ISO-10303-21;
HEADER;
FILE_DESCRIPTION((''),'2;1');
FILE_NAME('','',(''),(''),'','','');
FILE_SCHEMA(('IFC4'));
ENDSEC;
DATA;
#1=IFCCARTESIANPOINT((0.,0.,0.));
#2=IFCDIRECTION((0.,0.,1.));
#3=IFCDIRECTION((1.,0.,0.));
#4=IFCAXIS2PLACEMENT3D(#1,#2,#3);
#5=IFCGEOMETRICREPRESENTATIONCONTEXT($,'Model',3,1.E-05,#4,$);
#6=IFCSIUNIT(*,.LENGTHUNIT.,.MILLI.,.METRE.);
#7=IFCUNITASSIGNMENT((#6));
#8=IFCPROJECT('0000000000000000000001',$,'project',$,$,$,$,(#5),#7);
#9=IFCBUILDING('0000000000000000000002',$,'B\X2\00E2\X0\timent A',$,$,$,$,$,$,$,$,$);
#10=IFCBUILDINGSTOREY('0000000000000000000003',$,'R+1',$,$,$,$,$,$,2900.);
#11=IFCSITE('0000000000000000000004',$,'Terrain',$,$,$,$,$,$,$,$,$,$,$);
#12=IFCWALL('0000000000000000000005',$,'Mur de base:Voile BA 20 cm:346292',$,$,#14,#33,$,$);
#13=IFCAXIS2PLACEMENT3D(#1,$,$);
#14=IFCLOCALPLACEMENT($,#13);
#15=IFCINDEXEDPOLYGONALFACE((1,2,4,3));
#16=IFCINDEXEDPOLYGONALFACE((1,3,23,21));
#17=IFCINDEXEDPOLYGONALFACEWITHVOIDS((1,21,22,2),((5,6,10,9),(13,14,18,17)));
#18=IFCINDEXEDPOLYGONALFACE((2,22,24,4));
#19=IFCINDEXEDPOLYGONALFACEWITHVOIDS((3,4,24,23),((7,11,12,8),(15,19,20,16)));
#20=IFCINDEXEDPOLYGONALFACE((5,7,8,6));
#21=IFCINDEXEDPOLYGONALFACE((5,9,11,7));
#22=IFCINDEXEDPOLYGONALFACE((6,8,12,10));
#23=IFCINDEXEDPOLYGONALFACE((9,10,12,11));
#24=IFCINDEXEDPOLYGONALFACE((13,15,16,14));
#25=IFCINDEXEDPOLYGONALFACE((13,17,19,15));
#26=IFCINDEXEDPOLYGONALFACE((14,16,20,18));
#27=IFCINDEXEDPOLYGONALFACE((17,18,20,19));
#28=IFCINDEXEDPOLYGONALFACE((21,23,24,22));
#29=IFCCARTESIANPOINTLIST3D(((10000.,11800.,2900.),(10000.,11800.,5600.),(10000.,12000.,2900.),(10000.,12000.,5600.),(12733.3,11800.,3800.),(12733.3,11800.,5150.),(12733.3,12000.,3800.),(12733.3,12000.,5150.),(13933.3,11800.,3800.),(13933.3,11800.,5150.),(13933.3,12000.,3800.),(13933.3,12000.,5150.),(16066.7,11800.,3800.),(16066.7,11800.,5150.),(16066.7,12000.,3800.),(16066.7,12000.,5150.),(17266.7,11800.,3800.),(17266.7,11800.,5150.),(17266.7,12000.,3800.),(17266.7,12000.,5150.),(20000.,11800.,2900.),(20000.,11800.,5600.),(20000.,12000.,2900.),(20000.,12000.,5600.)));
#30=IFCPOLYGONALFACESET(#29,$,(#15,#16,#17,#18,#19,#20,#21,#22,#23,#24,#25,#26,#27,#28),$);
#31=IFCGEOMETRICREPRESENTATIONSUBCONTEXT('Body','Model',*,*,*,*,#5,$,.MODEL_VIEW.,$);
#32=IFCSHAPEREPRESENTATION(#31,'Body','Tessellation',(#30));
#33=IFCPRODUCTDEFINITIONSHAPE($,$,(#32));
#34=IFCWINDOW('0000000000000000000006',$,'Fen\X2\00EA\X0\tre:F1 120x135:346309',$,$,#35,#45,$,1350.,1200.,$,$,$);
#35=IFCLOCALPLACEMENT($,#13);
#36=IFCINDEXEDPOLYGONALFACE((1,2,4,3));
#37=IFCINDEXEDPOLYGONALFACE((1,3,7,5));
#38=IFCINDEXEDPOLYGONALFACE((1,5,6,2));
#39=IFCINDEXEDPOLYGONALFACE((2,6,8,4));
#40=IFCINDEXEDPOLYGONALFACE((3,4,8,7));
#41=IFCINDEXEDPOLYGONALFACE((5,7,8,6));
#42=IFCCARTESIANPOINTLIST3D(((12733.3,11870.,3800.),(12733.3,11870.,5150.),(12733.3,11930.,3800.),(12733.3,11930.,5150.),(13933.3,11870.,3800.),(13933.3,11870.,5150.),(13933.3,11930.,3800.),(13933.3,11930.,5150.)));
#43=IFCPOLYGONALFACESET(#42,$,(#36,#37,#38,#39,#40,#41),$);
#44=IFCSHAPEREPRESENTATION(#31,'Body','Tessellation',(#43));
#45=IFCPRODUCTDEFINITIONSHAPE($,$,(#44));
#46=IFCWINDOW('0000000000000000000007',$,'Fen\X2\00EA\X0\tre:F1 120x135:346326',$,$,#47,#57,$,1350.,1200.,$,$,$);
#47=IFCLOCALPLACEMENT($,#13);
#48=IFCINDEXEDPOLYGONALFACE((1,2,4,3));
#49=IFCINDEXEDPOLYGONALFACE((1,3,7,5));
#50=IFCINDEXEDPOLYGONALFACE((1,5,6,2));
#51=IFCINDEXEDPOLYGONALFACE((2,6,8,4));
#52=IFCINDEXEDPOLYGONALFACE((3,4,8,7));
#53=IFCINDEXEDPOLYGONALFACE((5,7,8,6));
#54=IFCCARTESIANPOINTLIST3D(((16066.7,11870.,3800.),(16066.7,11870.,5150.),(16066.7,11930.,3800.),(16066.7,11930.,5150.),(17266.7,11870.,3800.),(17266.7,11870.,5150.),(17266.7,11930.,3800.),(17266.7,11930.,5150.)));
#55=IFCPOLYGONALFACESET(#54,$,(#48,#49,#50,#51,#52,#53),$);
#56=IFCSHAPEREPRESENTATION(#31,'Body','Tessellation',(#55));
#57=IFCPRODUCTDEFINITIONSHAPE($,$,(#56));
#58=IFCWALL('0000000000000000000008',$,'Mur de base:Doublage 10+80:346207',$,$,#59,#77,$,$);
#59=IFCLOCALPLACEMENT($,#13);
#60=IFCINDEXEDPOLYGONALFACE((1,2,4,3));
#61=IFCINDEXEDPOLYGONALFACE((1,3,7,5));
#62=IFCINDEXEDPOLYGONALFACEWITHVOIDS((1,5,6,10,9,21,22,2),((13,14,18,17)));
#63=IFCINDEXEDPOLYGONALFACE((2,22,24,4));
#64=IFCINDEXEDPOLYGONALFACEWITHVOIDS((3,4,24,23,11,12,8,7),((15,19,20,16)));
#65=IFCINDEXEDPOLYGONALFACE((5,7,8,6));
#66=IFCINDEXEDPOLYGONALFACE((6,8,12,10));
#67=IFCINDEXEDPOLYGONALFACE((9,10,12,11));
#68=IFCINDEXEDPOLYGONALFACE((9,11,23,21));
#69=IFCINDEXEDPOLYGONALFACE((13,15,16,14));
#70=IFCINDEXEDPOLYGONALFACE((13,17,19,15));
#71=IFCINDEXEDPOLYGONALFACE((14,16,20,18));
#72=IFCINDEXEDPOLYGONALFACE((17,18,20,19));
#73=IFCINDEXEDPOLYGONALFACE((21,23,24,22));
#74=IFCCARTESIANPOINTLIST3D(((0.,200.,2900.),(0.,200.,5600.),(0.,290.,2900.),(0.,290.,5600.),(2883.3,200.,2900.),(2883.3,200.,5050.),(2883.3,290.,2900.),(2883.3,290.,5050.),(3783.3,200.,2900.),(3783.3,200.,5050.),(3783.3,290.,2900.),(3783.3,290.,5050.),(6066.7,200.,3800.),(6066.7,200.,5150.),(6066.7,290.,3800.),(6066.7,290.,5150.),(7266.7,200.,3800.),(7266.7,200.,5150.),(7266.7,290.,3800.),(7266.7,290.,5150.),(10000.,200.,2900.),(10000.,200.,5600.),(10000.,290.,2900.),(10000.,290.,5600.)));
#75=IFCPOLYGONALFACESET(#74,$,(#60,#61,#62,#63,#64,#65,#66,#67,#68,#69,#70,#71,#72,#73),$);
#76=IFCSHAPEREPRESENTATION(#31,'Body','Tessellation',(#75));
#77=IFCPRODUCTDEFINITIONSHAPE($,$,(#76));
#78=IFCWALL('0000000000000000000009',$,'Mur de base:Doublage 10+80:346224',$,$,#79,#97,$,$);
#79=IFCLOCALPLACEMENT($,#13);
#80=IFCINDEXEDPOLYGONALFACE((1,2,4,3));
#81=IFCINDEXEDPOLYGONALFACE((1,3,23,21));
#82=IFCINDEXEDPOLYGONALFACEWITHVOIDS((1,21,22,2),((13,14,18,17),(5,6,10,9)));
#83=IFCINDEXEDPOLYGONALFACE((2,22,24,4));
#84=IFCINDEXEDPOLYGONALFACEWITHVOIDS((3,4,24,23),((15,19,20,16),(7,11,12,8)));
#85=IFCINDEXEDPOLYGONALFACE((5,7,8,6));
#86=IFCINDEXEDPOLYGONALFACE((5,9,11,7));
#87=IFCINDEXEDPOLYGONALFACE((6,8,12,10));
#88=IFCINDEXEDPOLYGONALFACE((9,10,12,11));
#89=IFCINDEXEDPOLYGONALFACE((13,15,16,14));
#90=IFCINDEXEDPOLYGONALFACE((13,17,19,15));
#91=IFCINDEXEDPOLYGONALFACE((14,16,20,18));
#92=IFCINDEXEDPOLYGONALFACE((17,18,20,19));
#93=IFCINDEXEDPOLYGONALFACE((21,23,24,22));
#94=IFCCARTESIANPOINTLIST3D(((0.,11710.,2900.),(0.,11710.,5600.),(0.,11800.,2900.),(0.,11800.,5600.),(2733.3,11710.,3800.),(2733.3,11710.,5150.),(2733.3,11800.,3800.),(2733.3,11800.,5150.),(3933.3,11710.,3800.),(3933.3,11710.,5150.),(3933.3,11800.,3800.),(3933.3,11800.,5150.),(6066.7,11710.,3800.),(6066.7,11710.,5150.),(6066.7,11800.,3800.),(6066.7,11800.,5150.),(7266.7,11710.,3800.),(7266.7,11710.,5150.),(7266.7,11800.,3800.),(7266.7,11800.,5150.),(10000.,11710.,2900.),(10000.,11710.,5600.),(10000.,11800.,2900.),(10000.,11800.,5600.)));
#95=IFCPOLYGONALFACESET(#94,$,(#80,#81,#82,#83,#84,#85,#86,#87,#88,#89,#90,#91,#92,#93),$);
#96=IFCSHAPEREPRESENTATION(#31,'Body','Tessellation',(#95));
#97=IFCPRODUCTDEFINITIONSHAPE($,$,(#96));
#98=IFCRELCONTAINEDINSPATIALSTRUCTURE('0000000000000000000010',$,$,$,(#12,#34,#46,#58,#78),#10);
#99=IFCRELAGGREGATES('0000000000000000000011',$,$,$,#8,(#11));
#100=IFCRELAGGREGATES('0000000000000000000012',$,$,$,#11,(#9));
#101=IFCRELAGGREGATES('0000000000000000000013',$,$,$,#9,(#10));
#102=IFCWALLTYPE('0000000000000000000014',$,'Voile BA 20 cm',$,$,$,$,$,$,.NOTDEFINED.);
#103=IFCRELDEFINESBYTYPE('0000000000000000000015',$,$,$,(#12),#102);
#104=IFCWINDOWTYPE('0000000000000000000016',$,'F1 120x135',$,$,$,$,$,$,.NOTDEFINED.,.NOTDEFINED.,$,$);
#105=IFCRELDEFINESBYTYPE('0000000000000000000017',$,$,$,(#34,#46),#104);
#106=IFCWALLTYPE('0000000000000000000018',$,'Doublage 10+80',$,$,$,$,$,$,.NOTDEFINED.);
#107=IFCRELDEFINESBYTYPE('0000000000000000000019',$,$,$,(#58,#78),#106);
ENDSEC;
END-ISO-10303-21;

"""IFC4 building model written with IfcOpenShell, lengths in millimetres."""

from ifc_helpers import new_model, si_unit, frame, frame_2d, origin_with_axes, place, context, subcontext, project, spatial, rectangle, extrude, type_object, element, fill, save


model = new_model("IFC4")

# Units and contexts
model_context = context("Model", 3, precision=1e-05, world=origin_with_axes())
body_context = subcontext(model_context, "Body", "Model", "MODEL_VIEW")
ifc_project = project(units=[si_unit("LENGTHUNIT", "METRE", prefix="MILLI")], contexts=[model_context])

# Site, building, storey
site = spatial("IfcSite", under=ifc_project, Name="Terrain")
building = spatial("IfcBuilding", under=site, Name="Bâtiment A")
storey = spatial("IfcBuildingStorey", under=building, Name="R+1", Elevation=2900.0)

# Shared definitions
wall_type_1 = type_object("IfcWallType", Name="Voile BA 20 cm", PredefinedType="NOTDEFINED")
window_type = type_object("IfcWindowType", Name="F1 120x135", PartitioningType="NOTDEFINED", PredefinedType="NOTDEFINED")

# Wall, openings, windows
wall_1_placement = place(None, origin_with_axes())
wall_1 = element("IfcWall", 1, at=wall_1_placement, inside=storey, type_object=wall_type_1, Name="Mur de base:Voile BA 20 cm:346292", context=body_context, shape_type="SweptSolid", body=[
    extrude(rectangle(XDim=10000.0, YDim=200.0, at=frame_2d((15000.0, 11900.0))), frame((0.0, 0.0, 2900.0), z_axis=(0.0, 0.0, 1.0), x_axis=(1.0, 0.0, 0.0)), (0.0, 0.0, 1.0), 2700.0),
])
opening_1_placement = place(None, origin_with_axes())
opening_1 = element("IfcOpeningElement", 2, at=opening_1_placement, cuts=wall_1, context=body_context, shape_type="SweptSolid", body=[
    extrude(rectangle(XDim=1200.0, YDim=320.0, at=frame_2d((13333.3, 11900.0))), frame((0.0, 0.0, 3800.0), z_axis=(0.0, 0.0, 1.0), x_axis=(1.0, 0.0, 0.0)), (0.0, 0.0, 1.0), 1350.0),
])
opening_2_placement = place(None, origin_with_axes())
opening_2 = element("IfcOpeningElement", 3, at=opening_2_placement, cuts=wall_1, context=body_context, shape_type="SweptSolid", body=[
    extrude(rectangle(XDim=1200.0, YDim=320.0, at=frame_2d((16666.7, 11900.0))), frame((0.0, 0.0, 3800.0), z_axis=(0.0, 0.0, 1.0), x_axis=(1.0, 0.0, 0.0)), (0.0, 0.0, 1.0), 1350.0),
])
window_1_placement = place(None, origin_with_axes())
window_1 = element("IfcWindow", 4, at=window_1_placement, inside=storey, type_object=window_type, Name="Fenêtre:F1 120x135:346309", OverallHeight=1350.0, OverallWidth=1200.0, context=body_context, shape_type="SweptSolid", body=[
    extrude(rectangle(XDim=1200.0, YDim=60.0, at=frame_2d((13333.3, 11900.0))), frame((0.0, 0.0, 3800.0), z_axis=(0.0, 0.0, 1.0), x_axis=(1.0, 0.0, 0.0)), (0.0, 0.0, 1.0), 1350.0),
])
fill(opening_1, window_1)
window_2_placement = place(None, origin_with_axes())
window_2 = element("IfcWindow", 5, at=window_2_placement, inside=storey, type_object=window_type, Name="Fenêtre:F1 120x135:346326", OverallHeight=1350.0, OverallWidth=1200.0, context=body_context, shape_type="SweptSolid", body=[
    extrude(rectangle(XDim=1200.0, YDim=60.0, at=frame_2d((16666.7, 11900.0))), frame((0.0, 0.0, 3800.0), z_axis=(0.0, 0.0, 1.0), x_axis=(1.0, 0.0, 0.0)), (0.0, 0.0, 1.0), 1350.0),
])
fill(opening_2, window_2)

# Walls, openings
wall_type_2 = type_object("IfcWallType", Name="Doublage 10+80", PredefinedType="NOTDEFINED")
wall_2_placement = place(None, origin_with_axes())
wall_2 = element("IfcWall", 6, at=wall_2_placement, inside=storey, type_object=wall_type_2, Name="Mur de base:Doublage 10+80:346207", context=body_context, shape_type="SweptSolid", body=[
    extrude(rectangle(XDim=10000.0, YDim=90.0, at=frame_2d((5000.0, 245.0))), frame((0.0, 0.0, 2900.0), z_axis=(0.0, 0.0, 1.0), x_axis=(1.0, 0.0, 0.0)), (0.0, 0.0, 1.0), 2700.0),
])
opening_3_placement = place(None, origin_with_axes())
element("IfcOpeningElement", 7, at=opening_3_placement, cuts=wall_2, context=body_context, shape_type="SweptSolid", body=[
    extrude(rectangle(XDim=900.0, YDim=210.0, at=frame_2d((3333.3, 245.0))), frame((0.0, 0.0, 2900.0), z_axis=(0.0, 0.0, 1.0), x_axis=(1.0, 0.0, 0.0)), (0.0, 0.0, 1.0), 2150.0),
])
opening_4_placement = place(None, origin_with_axes())
element("IfcOpeningElement", 8, at=opening_4_placement, cuts=wall_2, context=body_context, shape_type="SweptSolid", body=[
    extrude(rectangle(XDim=1200.0, YDim=210.0, at=frame_2d((6666.7, 245.0))), frame((0.0, 0.0, 3800.0), z_axis=(0.0, 0.0, 1.0), x_axis=(1.0, 0.0, 0.0)), (0.0, 0.0, 1.0), 1350.0),
])
wall_3_placement = place(None, origin_with_axes())
wall_3 = element("IfcWall", 9, at=wall_3_placement, inside=storey, type_object=wall_type_2, Name="Mur de base:Doublage 10+80:346224", context=body_context, shape_type="SweptSolid", body=[
    extrude(rectangle(XDim=10000.0, YDim=90.0, at=frame_2d((5000.0, 11755.0))), frame((0.0, 0.0, 2900.0), z_axis=(0.0, 0.0, 1.0), x_axis=(1.0, 0.0, 0.0)), (0.0, 0.0, 1.0), 2700.0),
])
opening_5_placement = place(None, origin_with_axes())
element("IfcOpeningElement", 10, at=opening_5_placement, cuts=wall_3, context=body_context, shape_type="SweptSolid", body=[
    extrude(rectangle(XDim=1200.0, YDim=210.0, at=frame_2d((3333.3, 11755.0))), frame((0.0, 0.0, 3800.0), z_axis=(0.0, 0.0, 1.0), x_axis=(1.0, 0.0, 0.0)), (0.0, 0.0, 1.0), 1350.0),
])
opening_6_placement = place(None, origin_with_axes())
element("IfcOpeningElement", 11, at=opening_6_placement, cuts=wall_3, context=body_context, shape_type="SweptSolid", body=[
    extrude(rectangle(XDim=1200.0, YDim=210.0, at=frame_2d((6666.7, 11755.0))), frame((0.0, 0.0, 3800.0), z_axis=(0.0, 0.0, 1.0), x_axis=(1.0, 0.0, 0.0)), (0.0, 0.0, 1.0), 1350.0),
])

save(model, "model.ifc")
